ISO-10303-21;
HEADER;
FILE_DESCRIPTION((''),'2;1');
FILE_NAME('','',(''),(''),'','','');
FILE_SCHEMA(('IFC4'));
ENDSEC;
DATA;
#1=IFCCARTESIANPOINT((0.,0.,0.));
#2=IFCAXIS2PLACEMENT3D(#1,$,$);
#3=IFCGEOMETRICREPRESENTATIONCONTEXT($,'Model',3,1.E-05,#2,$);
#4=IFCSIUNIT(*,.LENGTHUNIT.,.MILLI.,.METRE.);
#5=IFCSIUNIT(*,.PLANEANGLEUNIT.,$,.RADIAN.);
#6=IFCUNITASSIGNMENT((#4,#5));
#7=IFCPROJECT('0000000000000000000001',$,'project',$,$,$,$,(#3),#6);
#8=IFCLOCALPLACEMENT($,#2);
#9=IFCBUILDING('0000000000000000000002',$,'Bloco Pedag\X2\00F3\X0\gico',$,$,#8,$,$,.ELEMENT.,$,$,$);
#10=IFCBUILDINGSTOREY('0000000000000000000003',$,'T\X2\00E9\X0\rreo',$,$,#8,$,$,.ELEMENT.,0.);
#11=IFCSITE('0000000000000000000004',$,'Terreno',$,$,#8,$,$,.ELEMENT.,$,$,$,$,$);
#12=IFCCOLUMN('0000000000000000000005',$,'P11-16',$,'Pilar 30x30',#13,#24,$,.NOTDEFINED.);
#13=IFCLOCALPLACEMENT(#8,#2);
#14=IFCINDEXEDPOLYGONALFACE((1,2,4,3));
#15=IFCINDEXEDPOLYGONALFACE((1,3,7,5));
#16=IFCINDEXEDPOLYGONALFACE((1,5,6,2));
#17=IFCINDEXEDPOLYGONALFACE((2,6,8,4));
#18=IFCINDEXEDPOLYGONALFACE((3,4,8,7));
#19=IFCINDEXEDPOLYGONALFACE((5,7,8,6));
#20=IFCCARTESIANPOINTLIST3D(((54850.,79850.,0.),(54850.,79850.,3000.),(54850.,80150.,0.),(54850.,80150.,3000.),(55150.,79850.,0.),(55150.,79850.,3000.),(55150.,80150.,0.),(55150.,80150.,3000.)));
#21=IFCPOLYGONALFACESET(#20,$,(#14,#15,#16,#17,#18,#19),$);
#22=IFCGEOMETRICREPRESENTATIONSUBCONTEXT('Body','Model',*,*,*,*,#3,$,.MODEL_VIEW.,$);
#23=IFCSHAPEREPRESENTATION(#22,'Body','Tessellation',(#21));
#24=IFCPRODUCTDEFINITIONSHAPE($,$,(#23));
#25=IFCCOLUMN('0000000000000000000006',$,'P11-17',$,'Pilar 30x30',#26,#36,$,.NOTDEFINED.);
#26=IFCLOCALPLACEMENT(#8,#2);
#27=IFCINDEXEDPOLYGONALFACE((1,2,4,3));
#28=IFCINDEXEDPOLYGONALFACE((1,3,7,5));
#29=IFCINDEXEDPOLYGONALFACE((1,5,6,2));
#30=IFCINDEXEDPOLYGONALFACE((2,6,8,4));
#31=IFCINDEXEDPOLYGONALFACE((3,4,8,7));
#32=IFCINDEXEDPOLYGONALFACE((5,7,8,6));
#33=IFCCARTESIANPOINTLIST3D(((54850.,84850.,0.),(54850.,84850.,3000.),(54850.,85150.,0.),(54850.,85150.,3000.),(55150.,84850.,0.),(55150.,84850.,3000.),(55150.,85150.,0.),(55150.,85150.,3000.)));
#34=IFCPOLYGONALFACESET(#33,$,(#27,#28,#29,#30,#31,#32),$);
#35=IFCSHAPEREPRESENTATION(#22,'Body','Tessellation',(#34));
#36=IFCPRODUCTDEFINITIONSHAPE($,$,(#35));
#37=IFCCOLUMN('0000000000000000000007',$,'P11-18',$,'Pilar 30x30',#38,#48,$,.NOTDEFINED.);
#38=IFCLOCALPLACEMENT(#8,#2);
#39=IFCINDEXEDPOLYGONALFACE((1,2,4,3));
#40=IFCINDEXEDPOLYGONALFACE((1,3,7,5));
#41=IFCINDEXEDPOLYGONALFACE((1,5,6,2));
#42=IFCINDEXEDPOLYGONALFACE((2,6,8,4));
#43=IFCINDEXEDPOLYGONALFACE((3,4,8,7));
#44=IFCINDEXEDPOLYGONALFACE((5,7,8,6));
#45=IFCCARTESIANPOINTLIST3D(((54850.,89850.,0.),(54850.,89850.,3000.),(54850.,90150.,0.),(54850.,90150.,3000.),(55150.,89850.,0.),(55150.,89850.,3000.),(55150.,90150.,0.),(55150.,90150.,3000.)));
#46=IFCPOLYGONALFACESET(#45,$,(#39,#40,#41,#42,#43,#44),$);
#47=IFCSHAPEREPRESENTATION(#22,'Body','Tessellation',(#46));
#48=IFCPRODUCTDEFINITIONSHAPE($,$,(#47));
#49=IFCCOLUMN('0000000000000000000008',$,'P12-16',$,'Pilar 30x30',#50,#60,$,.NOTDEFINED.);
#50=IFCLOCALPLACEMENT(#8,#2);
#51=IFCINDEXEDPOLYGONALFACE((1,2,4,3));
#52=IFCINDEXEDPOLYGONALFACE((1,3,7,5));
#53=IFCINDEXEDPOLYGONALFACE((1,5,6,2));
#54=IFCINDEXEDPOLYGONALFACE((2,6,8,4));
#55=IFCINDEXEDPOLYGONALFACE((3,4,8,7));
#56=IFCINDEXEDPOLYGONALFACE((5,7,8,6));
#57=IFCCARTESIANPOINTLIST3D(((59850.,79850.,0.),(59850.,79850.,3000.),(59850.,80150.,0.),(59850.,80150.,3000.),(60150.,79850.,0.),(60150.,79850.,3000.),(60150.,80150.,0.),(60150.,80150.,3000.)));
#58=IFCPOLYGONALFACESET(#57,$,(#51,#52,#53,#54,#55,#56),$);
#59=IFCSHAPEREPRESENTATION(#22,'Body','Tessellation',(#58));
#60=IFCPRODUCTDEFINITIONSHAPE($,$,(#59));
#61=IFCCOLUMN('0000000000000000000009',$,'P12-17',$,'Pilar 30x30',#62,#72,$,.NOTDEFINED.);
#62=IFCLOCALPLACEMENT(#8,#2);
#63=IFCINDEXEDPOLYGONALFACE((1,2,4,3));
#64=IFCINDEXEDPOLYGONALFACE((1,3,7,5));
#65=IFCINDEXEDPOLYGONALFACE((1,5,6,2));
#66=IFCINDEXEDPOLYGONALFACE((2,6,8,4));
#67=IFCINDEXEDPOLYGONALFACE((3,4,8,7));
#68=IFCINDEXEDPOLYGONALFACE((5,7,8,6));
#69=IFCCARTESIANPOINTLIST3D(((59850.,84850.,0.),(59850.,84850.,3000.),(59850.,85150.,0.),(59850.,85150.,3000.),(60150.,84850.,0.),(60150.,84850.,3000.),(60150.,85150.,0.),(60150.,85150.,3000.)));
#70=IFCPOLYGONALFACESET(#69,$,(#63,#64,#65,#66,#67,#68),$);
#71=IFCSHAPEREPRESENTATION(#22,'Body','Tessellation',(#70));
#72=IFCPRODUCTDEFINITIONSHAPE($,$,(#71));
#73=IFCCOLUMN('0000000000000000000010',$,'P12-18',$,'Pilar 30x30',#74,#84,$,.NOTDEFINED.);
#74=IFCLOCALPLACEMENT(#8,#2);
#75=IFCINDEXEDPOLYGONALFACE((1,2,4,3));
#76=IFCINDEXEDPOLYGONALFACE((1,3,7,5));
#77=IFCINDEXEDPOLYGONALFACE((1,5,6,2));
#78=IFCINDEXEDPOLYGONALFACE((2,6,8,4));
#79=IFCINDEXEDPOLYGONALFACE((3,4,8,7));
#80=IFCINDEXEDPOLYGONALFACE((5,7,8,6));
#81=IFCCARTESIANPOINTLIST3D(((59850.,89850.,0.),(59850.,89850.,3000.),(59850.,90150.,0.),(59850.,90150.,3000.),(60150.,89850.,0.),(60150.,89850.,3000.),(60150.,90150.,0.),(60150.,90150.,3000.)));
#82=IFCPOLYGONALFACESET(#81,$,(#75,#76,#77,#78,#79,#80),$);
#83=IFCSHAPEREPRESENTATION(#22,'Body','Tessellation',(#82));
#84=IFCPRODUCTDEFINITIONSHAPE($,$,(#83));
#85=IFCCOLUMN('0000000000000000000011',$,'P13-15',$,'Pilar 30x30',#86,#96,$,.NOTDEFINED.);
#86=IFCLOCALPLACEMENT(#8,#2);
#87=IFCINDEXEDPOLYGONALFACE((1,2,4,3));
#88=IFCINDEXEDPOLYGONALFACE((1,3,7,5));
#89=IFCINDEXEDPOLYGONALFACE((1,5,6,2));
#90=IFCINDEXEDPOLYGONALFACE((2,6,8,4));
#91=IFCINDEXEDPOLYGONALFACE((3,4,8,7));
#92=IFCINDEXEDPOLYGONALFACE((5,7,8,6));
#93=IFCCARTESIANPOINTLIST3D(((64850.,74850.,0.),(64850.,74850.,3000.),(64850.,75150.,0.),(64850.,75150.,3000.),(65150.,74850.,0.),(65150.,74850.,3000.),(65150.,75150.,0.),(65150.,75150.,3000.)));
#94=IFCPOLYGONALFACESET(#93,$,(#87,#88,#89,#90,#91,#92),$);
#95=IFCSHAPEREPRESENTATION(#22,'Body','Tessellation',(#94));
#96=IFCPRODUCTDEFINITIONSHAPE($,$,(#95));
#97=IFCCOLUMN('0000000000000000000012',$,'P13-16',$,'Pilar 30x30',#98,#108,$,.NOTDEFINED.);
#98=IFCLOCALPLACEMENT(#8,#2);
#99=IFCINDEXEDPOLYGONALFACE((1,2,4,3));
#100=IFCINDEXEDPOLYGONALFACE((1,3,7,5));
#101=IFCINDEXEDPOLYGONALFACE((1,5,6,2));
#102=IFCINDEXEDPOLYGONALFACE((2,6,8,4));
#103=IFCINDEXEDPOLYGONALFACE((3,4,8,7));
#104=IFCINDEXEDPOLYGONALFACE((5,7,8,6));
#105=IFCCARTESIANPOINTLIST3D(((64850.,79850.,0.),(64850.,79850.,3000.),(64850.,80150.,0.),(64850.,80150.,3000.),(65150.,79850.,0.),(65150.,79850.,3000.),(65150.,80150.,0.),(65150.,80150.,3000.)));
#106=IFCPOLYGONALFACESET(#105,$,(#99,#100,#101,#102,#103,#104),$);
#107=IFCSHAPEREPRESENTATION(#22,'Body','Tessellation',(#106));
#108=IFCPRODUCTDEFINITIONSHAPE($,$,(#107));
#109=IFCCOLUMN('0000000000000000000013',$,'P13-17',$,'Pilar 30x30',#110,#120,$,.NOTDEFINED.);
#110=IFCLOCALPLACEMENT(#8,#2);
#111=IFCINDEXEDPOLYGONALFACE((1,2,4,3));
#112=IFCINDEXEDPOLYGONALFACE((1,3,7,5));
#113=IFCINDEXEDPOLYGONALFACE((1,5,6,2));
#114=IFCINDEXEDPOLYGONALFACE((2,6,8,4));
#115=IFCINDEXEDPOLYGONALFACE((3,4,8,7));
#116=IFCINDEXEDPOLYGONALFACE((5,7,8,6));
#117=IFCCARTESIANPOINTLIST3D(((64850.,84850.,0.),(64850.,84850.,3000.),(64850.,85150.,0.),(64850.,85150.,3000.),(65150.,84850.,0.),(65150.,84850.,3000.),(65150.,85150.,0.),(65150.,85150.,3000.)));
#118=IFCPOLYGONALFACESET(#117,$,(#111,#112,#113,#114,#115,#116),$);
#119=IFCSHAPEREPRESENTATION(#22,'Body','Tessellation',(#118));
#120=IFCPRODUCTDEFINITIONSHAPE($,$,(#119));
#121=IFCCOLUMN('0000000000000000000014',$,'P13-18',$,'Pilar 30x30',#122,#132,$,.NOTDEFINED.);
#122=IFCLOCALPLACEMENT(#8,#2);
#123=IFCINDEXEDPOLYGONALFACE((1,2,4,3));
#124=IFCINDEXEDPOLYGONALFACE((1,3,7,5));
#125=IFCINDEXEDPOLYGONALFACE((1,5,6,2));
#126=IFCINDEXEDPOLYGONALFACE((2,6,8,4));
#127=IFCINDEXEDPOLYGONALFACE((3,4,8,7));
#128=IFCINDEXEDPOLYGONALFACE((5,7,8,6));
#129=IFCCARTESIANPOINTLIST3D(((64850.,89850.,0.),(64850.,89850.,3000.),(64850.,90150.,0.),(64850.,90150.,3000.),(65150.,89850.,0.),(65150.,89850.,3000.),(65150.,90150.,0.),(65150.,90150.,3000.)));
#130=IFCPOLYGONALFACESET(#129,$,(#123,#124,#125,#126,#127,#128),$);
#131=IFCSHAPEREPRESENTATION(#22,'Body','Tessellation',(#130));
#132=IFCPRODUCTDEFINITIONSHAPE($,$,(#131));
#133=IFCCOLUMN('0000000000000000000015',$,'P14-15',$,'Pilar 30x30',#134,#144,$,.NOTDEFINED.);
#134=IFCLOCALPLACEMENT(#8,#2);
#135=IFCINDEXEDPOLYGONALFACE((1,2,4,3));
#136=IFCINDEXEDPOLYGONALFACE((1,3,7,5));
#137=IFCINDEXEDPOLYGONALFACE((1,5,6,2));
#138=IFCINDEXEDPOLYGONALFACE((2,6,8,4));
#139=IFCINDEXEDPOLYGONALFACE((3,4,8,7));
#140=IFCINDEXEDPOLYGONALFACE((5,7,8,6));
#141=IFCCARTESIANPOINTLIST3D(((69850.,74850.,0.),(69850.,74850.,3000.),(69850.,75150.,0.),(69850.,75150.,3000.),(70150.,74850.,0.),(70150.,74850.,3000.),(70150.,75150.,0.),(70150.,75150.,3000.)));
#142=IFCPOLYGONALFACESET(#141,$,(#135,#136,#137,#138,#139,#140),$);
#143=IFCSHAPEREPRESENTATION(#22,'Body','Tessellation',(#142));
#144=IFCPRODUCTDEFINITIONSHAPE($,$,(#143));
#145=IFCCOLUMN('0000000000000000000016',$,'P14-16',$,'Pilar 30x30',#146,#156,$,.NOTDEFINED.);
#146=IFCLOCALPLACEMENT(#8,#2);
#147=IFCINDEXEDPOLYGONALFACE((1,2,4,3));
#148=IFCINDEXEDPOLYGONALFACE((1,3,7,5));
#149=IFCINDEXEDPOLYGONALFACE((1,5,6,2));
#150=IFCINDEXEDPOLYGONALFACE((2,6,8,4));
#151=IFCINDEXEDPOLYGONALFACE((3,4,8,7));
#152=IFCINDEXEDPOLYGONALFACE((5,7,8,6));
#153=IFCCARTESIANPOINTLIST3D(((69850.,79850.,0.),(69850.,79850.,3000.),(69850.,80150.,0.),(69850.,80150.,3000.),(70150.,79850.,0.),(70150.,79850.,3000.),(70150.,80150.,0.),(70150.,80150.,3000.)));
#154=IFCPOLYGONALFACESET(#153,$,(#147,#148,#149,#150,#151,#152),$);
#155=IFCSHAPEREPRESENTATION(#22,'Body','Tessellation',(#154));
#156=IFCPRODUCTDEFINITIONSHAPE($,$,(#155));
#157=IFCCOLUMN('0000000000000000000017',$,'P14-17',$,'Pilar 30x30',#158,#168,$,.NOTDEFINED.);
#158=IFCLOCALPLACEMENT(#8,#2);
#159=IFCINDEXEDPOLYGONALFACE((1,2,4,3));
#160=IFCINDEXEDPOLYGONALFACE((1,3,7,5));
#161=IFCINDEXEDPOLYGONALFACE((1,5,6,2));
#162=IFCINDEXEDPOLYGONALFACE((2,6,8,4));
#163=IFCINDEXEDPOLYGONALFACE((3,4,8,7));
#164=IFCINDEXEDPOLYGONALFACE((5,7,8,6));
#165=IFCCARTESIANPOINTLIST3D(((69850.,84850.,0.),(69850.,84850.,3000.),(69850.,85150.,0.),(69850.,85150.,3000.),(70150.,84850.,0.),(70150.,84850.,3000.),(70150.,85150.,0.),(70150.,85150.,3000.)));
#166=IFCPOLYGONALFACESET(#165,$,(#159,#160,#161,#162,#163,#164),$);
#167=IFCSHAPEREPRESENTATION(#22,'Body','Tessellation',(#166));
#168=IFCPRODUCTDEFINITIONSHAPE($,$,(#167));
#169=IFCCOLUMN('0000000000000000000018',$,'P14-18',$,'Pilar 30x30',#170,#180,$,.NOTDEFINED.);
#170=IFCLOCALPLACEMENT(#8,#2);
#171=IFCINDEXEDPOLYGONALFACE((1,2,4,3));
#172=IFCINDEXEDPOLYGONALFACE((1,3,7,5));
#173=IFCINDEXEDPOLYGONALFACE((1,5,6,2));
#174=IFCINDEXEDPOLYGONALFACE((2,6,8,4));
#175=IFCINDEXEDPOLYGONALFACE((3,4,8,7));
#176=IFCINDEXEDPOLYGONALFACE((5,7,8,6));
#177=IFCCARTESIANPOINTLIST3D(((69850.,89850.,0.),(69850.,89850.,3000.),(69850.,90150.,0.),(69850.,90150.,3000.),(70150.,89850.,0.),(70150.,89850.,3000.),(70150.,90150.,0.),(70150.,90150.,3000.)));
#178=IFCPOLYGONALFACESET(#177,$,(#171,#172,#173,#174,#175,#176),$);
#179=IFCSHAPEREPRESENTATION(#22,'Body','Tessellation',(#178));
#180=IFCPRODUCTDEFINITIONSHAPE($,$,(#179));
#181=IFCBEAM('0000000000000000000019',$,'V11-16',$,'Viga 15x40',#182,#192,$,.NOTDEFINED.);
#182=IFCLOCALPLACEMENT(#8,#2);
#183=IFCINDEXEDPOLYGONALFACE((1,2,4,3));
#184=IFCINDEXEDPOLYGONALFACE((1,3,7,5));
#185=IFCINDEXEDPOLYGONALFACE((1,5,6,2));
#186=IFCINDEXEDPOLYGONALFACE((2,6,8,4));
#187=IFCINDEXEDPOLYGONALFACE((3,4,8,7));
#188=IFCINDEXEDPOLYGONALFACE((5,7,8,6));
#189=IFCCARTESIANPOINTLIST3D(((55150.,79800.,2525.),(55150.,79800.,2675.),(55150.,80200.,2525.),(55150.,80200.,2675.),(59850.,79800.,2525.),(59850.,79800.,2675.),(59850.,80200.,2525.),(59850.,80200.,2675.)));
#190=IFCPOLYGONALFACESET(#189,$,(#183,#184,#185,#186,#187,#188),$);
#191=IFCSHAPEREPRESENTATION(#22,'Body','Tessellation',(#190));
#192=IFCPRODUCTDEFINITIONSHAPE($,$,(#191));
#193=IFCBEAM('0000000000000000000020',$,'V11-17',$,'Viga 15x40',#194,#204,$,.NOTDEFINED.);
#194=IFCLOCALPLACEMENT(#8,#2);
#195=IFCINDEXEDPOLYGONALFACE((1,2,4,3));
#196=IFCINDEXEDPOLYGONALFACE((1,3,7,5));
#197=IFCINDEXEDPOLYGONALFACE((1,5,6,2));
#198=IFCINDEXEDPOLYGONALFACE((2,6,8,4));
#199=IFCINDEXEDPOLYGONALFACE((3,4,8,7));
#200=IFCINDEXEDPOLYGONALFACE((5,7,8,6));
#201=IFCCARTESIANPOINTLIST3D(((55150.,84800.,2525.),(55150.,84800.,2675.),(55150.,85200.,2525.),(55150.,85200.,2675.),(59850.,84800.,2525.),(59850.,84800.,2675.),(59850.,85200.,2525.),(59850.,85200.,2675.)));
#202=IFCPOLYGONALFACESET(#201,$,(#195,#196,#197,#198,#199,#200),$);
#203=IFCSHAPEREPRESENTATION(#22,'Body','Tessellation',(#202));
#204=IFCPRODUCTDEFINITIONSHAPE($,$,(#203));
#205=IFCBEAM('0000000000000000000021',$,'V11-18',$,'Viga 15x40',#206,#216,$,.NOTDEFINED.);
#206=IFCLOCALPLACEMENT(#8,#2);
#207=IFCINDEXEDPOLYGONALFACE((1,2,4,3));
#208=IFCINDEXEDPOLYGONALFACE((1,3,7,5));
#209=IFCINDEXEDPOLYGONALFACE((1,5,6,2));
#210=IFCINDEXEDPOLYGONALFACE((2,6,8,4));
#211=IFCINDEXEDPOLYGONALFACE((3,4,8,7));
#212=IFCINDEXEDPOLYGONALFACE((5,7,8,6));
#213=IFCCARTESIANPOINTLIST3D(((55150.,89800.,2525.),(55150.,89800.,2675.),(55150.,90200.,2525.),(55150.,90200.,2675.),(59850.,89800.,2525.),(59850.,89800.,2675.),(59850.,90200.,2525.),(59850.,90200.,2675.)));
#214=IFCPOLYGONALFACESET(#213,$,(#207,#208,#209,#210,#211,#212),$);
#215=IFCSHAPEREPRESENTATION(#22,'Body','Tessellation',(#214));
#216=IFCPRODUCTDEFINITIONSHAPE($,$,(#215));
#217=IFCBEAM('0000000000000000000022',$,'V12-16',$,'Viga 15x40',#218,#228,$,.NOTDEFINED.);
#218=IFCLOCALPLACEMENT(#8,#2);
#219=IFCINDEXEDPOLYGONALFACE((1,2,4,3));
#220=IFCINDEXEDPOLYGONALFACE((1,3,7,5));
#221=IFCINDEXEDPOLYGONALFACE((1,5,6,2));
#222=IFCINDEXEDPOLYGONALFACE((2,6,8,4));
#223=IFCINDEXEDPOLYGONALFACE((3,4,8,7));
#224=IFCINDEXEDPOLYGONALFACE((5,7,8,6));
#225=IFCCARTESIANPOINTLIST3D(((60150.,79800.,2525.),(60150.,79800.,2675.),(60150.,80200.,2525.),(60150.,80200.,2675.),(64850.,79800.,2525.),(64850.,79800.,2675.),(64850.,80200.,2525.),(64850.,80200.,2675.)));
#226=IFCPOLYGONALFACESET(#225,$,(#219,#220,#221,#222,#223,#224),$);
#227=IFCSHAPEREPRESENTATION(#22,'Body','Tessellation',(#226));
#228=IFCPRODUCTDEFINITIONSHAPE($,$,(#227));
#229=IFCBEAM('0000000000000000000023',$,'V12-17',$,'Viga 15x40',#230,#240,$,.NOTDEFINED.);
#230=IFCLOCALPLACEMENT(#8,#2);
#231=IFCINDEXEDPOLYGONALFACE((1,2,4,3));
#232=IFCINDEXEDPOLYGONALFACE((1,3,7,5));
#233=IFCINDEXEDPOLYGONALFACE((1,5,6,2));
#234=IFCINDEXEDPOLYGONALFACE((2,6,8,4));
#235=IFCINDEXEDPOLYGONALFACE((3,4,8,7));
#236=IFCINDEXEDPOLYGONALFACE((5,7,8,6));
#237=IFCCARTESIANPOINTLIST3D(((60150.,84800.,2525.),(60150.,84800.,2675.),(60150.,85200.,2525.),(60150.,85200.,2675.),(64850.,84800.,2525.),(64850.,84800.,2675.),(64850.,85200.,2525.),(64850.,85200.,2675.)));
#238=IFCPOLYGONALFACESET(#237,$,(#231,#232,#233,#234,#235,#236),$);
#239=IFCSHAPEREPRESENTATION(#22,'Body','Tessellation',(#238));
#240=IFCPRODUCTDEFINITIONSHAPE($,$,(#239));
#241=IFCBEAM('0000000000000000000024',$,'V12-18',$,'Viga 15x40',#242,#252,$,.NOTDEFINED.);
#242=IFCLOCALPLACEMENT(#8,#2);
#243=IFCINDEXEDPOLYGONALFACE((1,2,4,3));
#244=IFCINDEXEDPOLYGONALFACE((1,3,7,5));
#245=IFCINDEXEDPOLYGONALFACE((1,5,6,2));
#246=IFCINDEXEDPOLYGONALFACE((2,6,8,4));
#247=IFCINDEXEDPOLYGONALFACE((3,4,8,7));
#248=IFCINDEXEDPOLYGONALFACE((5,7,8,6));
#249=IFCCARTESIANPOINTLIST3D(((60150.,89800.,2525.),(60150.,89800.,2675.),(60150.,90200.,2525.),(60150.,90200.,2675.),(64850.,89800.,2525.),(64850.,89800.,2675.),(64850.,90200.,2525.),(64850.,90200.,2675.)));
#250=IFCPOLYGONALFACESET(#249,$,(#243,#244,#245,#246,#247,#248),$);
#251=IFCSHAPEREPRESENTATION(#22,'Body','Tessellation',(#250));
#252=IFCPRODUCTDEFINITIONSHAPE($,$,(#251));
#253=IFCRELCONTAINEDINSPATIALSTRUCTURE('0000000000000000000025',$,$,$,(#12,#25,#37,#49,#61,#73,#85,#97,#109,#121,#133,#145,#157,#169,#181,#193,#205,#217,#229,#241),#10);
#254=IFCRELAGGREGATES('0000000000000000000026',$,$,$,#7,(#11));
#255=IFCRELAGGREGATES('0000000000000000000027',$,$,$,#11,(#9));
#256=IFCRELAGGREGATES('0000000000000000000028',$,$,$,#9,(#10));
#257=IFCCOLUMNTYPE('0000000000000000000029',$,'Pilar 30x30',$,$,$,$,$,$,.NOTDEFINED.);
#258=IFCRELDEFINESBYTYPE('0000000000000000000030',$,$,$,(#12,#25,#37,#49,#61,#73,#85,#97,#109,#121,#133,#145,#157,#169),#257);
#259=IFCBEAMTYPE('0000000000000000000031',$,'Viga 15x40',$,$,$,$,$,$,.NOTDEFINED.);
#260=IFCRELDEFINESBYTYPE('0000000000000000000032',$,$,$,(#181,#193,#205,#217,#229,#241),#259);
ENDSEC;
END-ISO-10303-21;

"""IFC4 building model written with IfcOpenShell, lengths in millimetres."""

from ifc_helpers import new_model, si_unit, frame, origin, origin_2d, place, context, subcontext, project, spatial, rectangle, extrude, type_object, element, save


model = new_model("IFC4")

# Units and contexts
model_context = context("Model", 3, precision=1e-05, world=origin())
body_context = subcontext(model_context, "Body", "Model", "MODEL_VIEW")
ifc_project = project(units=[si_unit("LENGTHUNIT", "METRE", prefix="MILLI"), si_unit("PLANEANGLEUNIT", "RADIAN")], contexts=[model_context])

# Site, building, storey
placement = place(None, origin())
site = spatial("IfcSite", under=ifc_project, at=placement, Name="Terreno", CompositionType="ELEMENT")
building = spatial("IfcBuilding", under=site, at=placement, Name="Bloco Pedagógico", CompositionType="ELEMENT")
storey = spatial("IfcBuildingStorey", under=building, at=placement, Name="Térreo", CompositionType="ELEMENT", Elevation=0.0)

# Columns
column_type = type_object("IfcColumnType", Name="Pilar 30x30", PredefinedType="NOTDEFINED")
for number, where, z_axis, x_axis, name in (
    (1, (55000.0, 80000.0, 0.0), (0.0, 0.0, 1.0), (1.0, 0.0, 0.0), "P11-16"),
    (2, (55000.0, 85000.0, 0.0), (0.0, 0.0, 1.0), (1.0, 0.0, 0.0), "P11-17"),
    (3, (55000.0, 90000.0, 0.0), (0.0, 0.0, 1.0), (1.0, 0.0, 0.0), "P11-18"),
    (4, (60000.0, 80000.0, 0.0), (0.0, 0.0, 1.0), (1.0, 0.0, 0.0), "P12-16"),
    (5, (60000.0, 85000.0, 0.0), (0.0, 0.0, 1.0), (1.0, 0.0, 0.0), "P12-17"),
    (6, (60000.0, 90000.0, 0.0), (0.0, 0.0, 1.0), (1.0, 0.0, 0.0), "P12-18"),
    (7, (65000.0, 75000.0, 0.0), (0.0, 0.0, 1.0), (1.0, 0.0, 0.0), "P13-15"),
    (8, (65000.0, 80000.0, 0.0), (0.0, 0.0, 1.0), (1.0, 0.0, 0.0), "P13-16"),
    (9, (65000.0, 85000.0, 0.0), (0.0, 0.0, 1.0), (1.0, 0.0, 0.0), "P13-17"),
    (10, (65000.0, 90000.0, 0.0), (0.0, 0.0, 1.0), (1.0, 0.0, 0.0), "P13-18"),
    (11, (70000.0, 75000.0, 0.0), (0.0, 0.0, 1.0), (1.0, 0.0, 0.0), "P14-15"),
    (12, (70000.0, 80000.0, 0.0), (0.0, 0.0, 1.0), (1.0, 0.0, 0.0), "P14-16"),
    (13, (70000.0, 85000.0, 0.0), (0.0, 0.0, 1.0), (1.0, 0.0, 0.0), "P14-17"),
    (14, (70000.0, 90000.0, 0.0), (0.0, 0.0, 1.0), (1.0, 0.0, 0.0), "P14-18"),
):
    element("IfcColumn", number, at=place(None, frame(where, z_axis=z_axis, x_axis=x_axis)), inside=storey, type_object=column_type, Name=name, ObjectType="Pilar 30x30", PredefinedType="NOTDEFINED", context=body_context, shape_type="SweptSolid", body=[
        extrude(rectangle(XDim=300.0, YDim=300.0, at=origin_2d()), None, (0.0, 0.0, 1.0), 3000.0),
    ])

# Beams
beam_type = type_object("IfcBeamType", Name="Viga 15x40", PredefinedType="NOTDEFINED")
for number, where, z_axis, x_axis, name in (
    (15, (55150.0, 80000.0, 2600.0), (1.0, 0.0, 0.0), (0.0, 1.0, 0.0), "V11-16"),
    (16, (55150.0, 85000.0, 2600.0), (1.0, 0.0, 0.0), (0.0, 1.0, 0.0), "V11-17"),
    (17, (55150.0, 90000.0, 2600.0), (1.0, 0.0, 0.0), (0.0, 1.0, 0.0), "V11-18"),
    (18, (60150.0, 80000.0, 2600.0), (1.0, 0.0, 0.0), (0.0, 1.0, 0.0), "V12-16"),
    (19, (60150.0, 85000.0, 2600.0), (1.0, 0.0, 0.0), (0.0, 1.0, 0.0), "V12-17"),
    (20, (60150.0, 90000.0, 2600.0), (1.0, 0.0, 0.0), (0.0, 1.0, 0.0), "V12-18"),
):
    element("IfcBeam", number, at=place(None, frame(where, z_axis=z_axis, x_axis=x_axis)), inside=storey, type_object=beam_type, Name=name, ObjectType="Viga 15x40", PredefinedType="NOTDEFINED", context=body_context, shape_type="SweptSolid", body=[
        extrude(rectangle(XDim=400.0, YDim=150.0, at=origin_2d()), None, (0.0, 0.0, 1.0), 4700.0),
    ])

save(model, "model.ifc")
